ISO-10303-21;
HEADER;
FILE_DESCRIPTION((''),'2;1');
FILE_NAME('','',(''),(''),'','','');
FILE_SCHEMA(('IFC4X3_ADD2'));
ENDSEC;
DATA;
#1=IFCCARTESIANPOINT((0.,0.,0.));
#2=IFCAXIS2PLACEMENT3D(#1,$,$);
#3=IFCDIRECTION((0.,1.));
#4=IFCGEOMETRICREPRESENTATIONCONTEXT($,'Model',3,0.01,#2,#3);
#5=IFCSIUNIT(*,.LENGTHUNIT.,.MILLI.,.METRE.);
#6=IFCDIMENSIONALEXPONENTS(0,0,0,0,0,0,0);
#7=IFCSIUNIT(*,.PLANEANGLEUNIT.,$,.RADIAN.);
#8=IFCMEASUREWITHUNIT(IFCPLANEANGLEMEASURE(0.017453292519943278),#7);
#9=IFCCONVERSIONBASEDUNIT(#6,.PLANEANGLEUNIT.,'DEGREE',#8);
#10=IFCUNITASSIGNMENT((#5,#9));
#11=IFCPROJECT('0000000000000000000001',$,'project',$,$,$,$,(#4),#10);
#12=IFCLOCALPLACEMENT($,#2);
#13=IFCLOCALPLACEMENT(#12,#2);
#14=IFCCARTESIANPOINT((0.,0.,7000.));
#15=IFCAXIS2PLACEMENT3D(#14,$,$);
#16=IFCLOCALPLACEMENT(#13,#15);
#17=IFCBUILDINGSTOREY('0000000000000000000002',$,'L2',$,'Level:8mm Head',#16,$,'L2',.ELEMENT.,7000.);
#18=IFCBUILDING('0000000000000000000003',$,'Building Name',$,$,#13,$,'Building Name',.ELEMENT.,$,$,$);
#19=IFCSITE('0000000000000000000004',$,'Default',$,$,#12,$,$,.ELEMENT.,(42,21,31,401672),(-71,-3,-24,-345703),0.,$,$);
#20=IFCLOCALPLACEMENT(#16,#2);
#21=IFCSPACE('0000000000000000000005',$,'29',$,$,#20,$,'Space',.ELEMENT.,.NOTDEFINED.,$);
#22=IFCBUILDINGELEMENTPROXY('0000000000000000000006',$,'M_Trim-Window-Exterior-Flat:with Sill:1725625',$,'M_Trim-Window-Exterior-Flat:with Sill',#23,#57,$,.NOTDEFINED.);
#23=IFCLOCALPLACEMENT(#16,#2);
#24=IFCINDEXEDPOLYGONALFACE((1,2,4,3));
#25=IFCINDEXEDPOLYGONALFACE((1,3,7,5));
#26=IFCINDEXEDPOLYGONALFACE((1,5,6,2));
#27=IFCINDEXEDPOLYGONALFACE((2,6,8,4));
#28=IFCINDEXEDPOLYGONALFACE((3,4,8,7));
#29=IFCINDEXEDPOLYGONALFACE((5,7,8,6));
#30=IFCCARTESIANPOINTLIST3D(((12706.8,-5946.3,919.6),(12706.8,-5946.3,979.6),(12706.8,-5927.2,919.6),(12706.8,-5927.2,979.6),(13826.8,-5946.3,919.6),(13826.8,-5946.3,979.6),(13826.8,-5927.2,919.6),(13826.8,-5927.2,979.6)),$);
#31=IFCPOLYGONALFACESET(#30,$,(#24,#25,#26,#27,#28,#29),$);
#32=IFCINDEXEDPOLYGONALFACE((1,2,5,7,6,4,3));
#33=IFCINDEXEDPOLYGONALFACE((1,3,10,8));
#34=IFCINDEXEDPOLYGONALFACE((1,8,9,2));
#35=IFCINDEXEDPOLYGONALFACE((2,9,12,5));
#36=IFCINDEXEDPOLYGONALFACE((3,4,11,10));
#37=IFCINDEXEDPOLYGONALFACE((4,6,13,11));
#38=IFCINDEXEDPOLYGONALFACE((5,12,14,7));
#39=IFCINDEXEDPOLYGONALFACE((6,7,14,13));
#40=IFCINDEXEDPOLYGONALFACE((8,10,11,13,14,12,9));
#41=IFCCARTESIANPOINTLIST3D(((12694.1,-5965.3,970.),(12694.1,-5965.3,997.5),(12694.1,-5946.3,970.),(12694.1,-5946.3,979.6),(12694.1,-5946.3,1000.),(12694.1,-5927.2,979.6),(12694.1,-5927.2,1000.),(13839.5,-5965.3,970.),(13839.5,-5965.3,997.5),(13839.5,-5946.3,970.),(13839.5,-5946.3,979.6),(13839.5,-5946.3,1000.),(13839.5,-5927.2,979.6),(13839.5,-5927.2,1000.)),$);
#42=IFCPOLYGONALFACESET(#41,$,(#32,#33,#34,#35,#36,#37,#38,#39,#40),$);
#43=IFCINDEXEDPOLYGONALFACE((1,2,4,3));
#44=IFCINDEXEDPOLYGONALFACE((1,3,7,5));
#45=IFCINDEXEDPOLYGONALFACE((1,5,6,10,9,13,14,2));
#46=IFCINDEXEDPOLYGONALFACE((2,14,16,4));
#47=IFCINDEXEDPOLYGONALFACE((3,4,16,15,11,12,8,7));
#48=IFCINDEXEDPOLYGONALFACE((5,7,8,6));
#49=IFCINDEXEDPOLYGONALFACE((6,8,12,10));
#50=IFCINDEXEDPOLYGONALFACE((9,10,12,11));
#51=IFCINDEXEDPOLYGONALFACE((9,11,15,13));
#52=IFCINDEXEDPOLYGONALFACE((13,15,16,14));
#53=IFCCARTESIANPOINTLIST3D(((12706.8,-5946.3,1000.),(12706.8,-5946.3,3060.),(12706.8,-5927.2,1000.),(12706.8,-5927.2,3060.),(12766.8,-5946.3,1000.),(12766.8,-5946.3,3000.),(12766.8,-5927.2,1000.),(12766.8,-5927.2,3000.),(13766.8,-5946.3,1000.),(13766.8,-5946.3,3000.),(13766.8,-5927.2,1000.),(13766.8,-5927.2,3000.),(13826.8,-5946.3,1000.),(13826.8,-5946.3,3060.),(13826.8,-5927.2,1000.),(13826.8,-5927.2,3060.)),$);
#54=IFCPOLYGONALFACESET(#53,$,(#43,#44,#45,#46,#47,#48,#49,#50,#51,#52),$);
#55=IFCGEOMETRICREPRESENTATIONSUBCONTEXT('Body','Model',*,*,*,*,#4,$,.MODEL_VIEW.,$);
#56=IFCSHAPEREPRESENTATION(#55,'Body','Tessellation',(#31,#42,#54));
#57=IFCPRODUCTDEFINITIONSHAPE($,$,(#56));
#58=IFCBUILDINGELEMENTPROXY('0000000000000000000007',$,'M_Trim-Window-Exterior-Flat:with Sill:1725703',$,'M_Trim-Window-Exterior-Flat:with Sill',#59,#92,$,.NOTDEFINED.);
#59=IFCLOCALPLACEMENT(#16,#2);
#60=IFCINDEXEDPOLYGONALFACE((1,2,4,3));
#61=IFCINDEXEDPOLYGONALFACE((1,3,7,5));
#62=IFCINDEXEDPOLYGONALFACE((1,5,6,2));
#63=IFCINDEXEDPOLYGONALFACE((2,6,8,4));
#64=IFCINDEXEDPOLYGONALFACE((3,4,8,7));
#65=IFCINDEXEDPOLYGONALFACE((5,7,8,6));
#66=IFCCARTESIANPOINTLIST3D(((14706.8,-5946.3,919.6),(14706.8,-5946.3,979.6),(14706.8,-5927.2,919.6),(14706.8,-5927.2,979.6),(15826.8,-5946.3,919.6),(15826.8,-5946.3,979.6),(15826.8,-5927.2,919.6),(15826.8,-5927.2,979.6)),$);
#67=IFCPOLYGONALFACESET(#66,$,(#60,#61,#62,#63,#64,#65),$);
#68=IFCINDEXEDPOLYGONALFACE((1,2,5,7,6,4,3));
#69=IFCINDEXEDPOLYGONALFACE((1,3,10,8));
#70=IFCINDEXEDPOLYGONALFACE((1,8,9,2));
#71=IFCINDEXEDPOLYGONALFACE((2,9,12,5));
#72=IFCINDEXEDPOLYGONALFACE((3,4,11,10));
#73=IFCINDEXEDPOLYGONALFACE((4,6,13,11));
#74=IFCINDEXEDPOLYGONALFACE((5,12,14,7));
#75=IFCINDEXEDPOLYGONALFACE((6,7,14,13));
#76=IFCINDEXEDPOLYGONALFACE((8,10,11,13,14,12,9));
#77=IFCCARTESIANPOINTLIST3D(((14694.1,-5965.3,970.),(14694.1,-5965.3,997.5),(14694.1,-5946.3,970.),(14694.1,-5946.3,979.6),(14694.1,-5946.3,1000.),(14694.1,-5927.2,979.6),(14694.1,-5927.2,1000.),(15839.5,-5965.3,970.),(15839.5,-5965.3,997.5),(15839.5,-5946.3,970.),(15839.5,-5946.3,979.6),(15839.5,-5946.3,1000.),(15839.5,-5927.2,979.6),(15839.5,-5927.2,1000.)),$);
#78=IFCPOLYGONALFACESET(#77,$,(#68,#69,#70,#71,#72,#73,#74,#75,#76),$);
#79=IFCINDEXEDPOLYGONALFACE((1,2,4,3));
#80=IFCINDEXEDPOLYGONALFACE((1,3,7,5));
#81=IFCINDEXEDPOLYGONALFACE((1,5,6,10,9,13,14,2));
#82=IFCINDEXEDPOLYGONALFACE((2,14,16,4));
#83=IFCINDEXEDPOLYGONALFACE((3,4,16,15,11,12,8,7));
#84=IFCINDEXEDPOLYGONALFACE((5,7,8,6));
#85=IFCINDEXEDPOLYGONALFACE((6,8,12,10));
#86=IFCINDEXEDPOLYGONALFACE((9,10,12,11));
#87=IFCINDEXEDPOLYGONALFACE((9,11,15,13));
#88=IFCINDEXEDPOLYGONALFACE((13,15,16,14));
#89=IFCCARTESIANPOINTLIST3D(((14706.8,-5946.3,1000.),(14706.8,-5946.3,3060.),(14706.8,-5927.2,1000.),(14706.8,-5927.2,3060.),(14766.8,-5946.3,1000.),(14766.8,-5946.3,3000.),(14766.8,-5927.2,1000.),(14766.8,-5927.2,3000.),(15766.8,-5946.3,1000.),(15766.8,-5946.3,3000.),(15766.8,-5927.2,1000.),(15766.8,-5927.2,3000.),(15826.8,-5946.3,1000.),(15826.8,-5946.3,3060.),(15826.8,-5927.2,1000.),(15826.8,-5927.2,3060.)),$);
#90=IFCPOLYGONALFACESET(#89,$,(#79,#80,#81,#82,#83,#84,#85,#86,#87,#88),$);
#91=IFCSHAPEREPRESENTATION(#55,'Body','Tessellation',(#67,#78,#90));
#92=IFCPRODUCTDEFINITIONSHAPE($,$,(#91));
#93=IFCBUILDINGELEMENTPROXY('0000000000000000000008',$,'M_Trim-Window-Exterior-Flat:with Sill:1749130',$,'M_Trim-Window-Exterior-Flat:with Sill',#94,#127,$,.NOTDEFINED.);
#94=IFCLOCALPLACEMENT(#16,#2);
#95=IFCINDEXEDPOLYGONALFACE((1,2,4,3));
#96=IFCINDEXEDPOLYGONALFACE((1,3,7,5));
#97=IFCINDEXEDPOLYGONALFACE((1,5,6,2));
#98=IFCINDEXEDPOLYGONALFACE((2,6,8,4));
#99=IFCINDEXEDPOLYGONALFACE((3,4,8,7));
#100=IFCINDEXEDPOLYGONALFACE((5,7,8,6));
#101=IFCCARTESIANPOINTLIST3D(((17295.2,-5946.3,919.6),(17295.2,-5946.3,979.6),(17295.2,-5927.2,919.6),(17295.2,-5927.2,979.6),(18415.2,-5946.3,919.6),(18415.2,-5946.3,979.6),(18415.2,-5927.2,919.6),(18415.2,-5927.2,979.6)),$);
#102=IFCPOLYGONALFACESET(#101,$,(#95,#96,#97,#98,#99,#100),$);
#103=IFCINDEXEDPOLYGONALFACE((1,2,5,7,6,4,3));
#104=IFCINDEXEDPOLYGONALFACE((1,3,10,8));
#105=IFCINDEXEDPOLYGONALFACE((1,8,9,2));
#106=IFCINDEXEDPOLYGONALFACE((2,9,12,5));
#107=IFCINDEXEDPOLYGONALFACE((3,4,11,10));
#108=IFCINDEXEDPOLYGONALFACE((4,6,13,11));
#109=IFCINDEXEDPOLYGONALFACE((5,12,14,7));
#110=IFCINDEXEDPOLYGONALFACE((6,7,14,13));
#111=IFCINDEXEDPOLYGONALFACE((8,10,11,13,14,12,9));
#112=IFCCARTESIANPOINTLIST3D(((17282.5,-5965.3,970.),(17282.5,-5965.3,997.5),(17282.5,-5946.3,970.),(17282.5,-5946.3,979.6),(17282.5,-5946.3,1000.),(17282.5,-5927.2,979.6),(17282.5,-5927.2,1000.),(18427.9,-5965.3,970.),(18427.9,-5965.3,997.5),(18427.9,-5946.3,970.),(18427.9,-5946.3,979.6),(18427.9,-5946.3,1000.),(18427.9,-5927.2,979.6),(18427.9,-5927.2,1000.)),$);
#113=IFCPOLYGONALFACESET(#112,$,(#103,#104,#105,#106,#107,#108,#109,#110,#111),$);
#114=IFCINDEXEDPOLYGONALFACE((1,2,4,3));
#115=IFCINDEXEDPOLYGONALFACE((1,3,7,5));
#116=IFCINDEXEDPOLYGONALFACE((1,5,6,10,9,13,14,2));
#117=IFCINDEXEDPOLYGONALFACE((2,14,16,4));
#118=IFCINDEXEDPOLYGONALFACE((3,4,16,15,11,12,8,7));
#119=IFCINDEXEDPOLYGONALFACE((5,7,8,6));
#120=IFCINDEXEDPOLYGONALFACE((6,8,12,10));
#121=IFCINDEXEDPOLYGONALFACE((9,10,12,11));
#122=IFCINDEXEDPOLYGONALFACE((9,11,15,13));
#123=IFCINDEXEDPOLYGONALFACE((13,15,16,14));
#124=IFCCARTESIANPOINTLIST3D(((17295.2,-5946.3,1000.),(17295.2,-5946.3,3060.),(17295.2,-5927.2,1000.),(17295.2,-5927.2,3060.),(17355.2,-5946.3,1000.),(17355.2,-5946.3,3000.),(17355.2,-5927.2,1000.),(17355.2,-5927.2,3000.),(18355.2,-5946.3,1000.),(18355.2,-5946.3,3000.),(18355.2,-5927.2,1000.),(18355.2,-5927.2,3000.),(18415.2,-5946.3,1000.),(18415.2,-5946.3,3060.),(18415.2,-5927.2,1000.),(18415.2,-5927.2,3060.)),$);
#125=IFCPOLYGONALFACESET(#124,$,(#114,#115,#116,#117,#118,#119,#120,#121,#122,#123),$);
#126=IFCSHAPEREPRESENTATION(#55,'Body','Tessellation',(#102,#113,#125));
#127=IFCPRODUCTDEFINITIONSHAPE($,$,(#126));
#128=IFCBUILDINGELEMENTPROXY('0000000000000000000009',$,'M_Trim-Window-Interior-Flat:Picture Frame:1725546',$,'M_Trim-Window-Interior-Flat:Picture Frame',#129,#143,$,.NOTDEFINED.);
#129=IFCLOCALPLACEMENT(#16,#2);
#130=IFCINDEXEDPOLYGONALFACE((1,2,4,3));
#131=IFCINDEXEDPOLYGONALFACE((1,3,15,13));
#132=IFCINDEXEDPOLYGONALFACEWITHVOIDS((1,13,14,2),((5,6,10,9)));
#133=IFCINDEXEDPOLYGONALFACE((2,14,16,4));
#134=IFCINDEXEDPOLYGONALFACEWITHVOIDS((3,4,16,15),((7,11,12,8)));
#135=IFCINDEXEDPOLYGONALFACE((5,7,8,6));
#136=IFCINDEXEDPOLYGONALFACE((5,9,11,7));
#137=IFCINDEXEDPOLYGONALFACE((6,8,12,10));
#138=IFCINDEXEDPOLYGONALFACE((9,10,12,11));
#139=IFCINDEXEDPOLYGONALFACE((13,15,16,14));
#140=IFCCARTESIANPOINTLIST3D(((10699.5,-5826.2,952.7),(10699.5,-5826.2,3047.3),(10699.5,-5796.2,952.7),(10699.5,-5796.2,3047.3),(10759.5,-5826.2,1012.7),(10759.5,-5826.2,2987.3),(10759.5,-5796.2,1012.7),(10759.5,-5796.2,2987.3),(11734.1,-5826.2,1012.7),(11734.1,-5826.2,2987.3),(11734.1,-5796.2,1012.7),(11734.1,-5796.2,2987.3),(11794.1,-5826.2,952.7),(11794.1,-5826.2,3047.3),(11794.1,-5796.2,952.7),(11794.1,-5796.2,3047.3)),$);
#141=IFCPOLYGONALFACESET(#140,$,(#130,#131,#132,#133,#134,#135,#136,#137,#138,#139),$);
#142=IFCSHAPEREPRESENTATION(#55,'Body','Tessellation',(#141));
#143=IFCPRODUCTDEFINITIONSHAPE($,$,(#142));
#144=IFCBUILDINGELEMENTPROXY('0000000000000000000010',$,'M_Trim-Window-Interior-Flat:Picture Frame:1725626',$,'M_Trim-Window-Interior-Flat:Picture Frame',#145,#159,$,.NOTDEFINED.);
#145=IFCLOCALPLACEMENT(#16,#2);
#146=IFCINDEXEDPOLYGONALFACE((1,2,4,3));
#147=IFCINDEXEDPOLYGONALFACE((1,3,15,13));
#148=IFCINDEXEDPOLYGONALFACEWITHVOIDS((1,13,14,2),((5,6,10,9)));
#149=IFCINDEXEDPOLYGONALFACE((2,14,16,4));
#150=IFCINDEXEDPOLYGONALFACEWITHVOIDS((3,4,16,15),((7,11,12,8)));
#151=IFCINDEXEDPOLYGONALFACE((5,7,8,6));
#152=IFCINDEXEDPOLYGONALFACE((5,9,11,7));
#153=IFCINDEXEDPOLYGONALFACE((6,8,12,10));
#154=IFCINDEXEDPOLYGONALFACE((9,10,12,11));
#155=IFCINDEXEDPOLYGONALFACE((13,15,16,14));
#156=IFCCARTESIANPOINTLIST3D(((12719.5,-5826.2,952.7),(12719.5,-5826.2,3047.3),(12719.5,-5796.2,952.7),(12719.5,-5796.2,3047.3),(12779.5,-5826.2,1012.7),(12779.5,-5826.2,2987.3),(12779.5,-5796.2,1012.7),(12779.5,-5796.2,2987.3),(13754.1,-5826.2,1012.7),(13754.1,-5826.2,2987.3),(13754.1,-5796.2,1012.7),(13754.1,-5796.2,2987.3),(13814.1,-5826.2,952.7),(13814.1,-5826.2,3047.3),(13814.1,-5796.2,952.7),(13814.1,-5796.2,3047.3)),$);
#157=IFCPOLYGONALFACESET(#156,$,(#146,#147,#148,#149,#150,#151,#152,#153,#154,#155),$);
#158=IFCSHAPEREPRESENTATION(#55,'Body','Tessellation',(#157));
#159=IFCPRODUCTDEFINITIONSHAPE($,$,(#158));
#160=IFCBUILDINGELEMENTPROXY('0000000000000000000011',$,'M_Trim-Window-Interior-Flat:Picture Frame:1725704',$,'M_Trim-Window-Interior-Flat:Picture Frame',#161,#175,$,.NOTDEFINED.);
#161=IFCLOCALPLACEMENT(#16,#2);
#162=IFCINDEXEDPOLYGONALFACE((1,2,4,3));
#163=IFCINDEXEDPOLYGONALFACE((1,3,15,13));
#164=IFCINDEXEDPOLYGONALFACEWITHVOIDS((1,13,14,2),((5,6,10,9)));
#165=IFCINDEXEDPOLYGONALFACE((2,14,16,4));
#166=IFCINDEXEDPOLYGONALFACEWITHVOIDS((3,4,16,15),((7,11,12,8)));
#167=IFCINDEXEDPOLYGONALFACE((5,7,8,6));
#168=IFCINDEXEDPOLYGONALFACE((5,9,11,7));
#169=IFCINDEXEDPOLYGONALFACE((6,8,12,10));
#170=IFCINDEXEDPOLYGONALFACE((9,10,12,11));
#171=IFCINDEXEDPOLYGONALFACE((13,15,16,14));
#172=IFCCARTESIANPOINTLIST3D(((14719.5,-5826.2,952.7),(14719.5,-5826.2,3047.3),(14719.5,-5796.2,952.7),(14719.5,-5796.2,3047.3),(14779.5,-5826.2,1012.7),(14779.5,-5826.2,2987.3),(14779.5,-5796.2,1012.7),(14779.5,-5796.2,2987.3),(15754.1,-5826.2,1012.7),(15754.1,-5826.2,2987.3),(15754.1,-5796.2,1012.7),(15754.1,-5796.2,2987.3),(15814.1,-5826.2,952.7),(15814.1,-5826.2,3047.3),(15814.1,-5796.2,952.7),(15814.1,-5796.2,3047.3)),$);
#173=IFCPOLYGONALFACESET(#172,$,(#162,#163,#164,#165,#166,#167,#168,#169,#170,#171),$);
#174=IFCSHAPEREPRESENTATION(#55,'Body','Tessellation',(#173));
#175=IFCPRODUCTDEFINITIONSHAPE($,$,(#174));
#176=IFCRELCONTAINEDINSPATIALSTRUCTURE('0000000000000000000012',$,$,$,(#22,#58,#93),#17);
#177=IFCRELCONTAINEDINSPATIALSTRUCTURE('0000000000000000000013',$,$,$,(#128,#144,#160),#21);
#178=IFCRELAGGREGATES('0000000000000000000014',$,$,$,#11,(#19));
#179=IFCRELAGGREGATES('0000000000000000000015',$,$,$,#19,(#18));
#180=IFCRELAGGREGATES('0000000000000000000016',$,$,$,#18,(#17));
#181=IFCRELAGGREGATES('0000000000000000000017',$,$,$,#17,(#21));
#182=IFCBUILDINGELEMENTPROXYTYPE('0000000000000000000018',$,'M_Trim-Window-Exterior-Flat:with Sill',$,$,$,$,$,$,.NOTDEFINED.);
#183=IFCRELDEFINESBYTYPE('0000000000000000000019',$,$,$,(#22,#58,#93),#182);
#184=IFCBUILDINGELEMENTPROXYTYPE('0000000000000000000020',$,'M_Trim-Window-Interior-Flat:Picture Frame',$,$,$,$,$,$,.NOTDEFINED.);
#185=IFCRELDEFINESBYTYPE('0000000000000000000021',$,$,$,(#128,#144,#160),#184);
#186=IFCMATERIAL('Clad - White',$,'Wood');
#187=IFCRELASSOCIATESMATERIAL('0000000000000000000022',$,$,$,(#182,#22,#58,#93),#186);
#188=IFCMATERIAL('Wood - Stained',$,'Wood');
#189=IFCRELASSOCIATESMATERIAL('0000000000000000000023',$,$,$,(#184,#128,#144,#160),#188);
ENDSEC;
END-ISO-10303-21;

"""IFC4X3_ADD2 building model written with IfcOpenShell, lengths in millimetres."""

from ifc_helpers import new_model, entity, si_unit, converted_unit, direction, frame, frame_2d, origin, place, context, subcontext, project, spatial, polyline, rectangle, outline, extrude, source, transform, mapped, material, type_object, type_shapes, element, save


model = new_model("IFC4X3_ADD2")

# Units and contexts
model_context = context("Model", 3, precision=0.01, world=origin(), true_north=direction((0.0, 1.0)))
body_context = subcontext(model_context, "Body", "Model", "MODEL_VIEW")
ifc_project = project(units=[si_unit("LENGTHUNIT", "METRE", prefix="MILLI"), converted_unit("PLANEANGLEUNIT", "DEGREE", entity("IfcPlaneAngleMeasure", 0.017453292519943278), si_unit("PLANEANGLEUNIT", "RADIAN"), dimensions=[0, 0, 0, 0, 0, 0, 0])], contexts=[model_context])

# Site, building, storey
site_placement = place(None, origin())
site = spatial("IfcSite", under=ifc_project, at=site_placement, Name="Default", CompositionType="ELEMENT", RefLatitude=(42, 21, 31, 401672), RefLongitude=(-71, -3, -24, -345703), RefElevation=0.0)
building_placement = place(site_placement, origin())
building = spatial("IfcBuilding", under=site, at=building_placement, Name="Building Name", LongName="Building Name", CompositionType="ELEMENT")
storey_placement = place(building_placement, frame((0.0, 0.0, 7000.0)))
storey = spatial("IfcBuildingStorey", under=building, at=storey_placement, Name="L2", ObjectType="Level:8mm Head", LongName="L2", CompositionType="ELEMENT", Elevation=7000.0)

# Building element proxies
ifc_material_1 = material(Name="Clad - White", Category="Wood")
ifc_material_2 = material(Name="Wood - Stained", Category="Wood")
building_element_proxy_type_1 = type_object("IfcBuildingElementProxyType", Name="M_Trim-Window-Exterior-Flat:with Sill", PredefinedType="NOTDEFINED", material=ifc_material_1)
shared_shape_1 = source(origin(), body_context, "Body", "SweptSolid", [
    extrude(rectangle(XDim=1120.0, YDim=60.0, at=frame_2d((0.0, 0.0), x_axis=(1.0, 0.0))), frame((0.0, -2050.4, 0.0), z_axis=(0.0, 0.0, 1.0), x_axis=(-1.0, 0.0, 0.0)), (0.0, 0.0, 1.0), 19.0),
    extrude(outline(polyline([(-19.0, -15.2), (0.0, -15.2), (0.0, -5.7), (19.0, -5.7), (19.0, 14.8), (0.0, 14.8), (-19.0, 12.3), (-19.0, -15.2)])), frame((-572.7, -2014.8, 19.0), z_axis=(1.0, 0.0, 0.0), x_axis=(0.0, 0.0, -1.0)), (0.0, 0.0, 1.0), 1145.4),
    extrude(outline(polyline([(-1045.0, -560.0), (1015.0, -560.0), (1015.0, -500.0), (-985.0, -500.0), (-985.0, 500.0), (1015.0, 500.0), (1015.0, 560.0), (-1045.0, 560.0), (-1045.0, -560.0)])), frame((0.0, -985.0, 0.0), z_axis=(0.0, 0.0, 1.0), x_axis=(0.0, -1.0, 0.0)), (0.0, 0.0, 1.0), 19.0),
])
type_shapes(building_element_proxy_type_1, [shared_shape_1])
for number, where, z_axis, x_axis, name in (
    (1, (13266.8, -5927.2, 3000.0), (0.0, -1.0, 0.0), (1.0, 0.0, 0.0), "M_Trim-Window-Exterior-Flat:with Sill:1725625"),
    (2, (15266.8, -5927.2, 3000.0), (0.0, -1.0, 0.0), (1.0, 0.0, 0.0), "M_Trim-Window-Exterior-Flat:with Sill:1725703"),
    (3, (17855.2, -5927.2, 3000.0), (0.0, -1.0, 0.0), (1.0, 0.0, 0.0), "M_Trim-Window-Exterior-Flat:with Sill:1749130"),
):
    element("IfcBuildingElementProxy", number, at=place(storey_placement, frame(where, z_axis=z_axis, x_axis=x_axis)), inside=storey, type_object=building_element_proxy_type_1, material=ifc_material_1, Name=name, ObjectType="M_Trim-Window-Exterior-Flat:with Sill", PredefinedType="NOTDEFINED", context=body_context, shape_type="MappedRepresentation", body=[
        mapped(shared_shape_1, transform((0.0, 0.0, 0.0), scale=1.0)),
    ])

# Shared definitions
space_placement = place(storey_placement, origin())
space = spatial("IfcSpace", under=storey, at=space_placement, Name="29", LongName="Space", CompositionType="ELEMENT", PredefinedType="NOTDEFINED")

# Building element proxies
building_element_proxy_type_2 = type_object("IfcBuildingElementProxyType", Name="M_Trim-Window-Interior-Flat:Picture Frame", PredefinedType="NOTDEFINED", material=ifc_material_2)
shared_shape_2 = source(origin(), body_context, "Body", "SweptSolid", [
    extrude(outline(polyline([(-547.3, -1047.3), (547.3, -1047.3), (547.3, 1047.3), (-547.3, 1047.3), (-547.3, -1047.3)]), holes=[polyline([(-487.3, -987.3), (-487.3, 987.3), (487.3, 987.3), (487.3, -987.3), (-487.3, -987.3)])]), frame((0.0, -1000.0, 0.0), z_axis=(0.0, 0.0, 1.0), x_axis=(-1.0, 0.0, 0.0)), (0.0, 0.0, 1.0), 30.0),
])
type_shapes(building_element_proxy_type_2, [shared_shape_2])
for number, where, z_axis, x_axis, name in (
    (4, (11246.8, -5826.2, 3000.0), (0.0, 1.0, 0.0), (-1.0, 0.0, 0.0), "M_Trim-Window-Interior-Flat:Picture Frame:1725546"),
    (5, (13266.8, -5826.2, 3000.0), (0.0, 1.0, 0.0), (-1.0, 0.0, 0.0), "M_Trim-Window-Interior-Flat:Picture Frame:1725626"),
    (6, (15266.8, -5826.2, 3000.0), (0.0, 1.0, 0.0), (-1.0, 0.0, 0.0), "M_Trim-Window-Interior-Flat:Picture Frame:1725704"),
):
    element("IfcBuildingElementProxy", number, at=place(space_placement, frame(where, z_axis=z_axis, x_axis=x_axis)), inside=space, type_object=building_element_proxy_type_2, material=ifc_material_2, Name=name, ObjectType="M_Trim-Window-Interior-Flat:Picture Frame", PredefinedType="NOTDEFINED", context=body_context, shape_type="MappedRepresentation", body=[
        mapped(shared_shape_2, transform((0.0, 0.0, 0.0), scale=1.0)),
    ])

save(model, "model.ifc")
